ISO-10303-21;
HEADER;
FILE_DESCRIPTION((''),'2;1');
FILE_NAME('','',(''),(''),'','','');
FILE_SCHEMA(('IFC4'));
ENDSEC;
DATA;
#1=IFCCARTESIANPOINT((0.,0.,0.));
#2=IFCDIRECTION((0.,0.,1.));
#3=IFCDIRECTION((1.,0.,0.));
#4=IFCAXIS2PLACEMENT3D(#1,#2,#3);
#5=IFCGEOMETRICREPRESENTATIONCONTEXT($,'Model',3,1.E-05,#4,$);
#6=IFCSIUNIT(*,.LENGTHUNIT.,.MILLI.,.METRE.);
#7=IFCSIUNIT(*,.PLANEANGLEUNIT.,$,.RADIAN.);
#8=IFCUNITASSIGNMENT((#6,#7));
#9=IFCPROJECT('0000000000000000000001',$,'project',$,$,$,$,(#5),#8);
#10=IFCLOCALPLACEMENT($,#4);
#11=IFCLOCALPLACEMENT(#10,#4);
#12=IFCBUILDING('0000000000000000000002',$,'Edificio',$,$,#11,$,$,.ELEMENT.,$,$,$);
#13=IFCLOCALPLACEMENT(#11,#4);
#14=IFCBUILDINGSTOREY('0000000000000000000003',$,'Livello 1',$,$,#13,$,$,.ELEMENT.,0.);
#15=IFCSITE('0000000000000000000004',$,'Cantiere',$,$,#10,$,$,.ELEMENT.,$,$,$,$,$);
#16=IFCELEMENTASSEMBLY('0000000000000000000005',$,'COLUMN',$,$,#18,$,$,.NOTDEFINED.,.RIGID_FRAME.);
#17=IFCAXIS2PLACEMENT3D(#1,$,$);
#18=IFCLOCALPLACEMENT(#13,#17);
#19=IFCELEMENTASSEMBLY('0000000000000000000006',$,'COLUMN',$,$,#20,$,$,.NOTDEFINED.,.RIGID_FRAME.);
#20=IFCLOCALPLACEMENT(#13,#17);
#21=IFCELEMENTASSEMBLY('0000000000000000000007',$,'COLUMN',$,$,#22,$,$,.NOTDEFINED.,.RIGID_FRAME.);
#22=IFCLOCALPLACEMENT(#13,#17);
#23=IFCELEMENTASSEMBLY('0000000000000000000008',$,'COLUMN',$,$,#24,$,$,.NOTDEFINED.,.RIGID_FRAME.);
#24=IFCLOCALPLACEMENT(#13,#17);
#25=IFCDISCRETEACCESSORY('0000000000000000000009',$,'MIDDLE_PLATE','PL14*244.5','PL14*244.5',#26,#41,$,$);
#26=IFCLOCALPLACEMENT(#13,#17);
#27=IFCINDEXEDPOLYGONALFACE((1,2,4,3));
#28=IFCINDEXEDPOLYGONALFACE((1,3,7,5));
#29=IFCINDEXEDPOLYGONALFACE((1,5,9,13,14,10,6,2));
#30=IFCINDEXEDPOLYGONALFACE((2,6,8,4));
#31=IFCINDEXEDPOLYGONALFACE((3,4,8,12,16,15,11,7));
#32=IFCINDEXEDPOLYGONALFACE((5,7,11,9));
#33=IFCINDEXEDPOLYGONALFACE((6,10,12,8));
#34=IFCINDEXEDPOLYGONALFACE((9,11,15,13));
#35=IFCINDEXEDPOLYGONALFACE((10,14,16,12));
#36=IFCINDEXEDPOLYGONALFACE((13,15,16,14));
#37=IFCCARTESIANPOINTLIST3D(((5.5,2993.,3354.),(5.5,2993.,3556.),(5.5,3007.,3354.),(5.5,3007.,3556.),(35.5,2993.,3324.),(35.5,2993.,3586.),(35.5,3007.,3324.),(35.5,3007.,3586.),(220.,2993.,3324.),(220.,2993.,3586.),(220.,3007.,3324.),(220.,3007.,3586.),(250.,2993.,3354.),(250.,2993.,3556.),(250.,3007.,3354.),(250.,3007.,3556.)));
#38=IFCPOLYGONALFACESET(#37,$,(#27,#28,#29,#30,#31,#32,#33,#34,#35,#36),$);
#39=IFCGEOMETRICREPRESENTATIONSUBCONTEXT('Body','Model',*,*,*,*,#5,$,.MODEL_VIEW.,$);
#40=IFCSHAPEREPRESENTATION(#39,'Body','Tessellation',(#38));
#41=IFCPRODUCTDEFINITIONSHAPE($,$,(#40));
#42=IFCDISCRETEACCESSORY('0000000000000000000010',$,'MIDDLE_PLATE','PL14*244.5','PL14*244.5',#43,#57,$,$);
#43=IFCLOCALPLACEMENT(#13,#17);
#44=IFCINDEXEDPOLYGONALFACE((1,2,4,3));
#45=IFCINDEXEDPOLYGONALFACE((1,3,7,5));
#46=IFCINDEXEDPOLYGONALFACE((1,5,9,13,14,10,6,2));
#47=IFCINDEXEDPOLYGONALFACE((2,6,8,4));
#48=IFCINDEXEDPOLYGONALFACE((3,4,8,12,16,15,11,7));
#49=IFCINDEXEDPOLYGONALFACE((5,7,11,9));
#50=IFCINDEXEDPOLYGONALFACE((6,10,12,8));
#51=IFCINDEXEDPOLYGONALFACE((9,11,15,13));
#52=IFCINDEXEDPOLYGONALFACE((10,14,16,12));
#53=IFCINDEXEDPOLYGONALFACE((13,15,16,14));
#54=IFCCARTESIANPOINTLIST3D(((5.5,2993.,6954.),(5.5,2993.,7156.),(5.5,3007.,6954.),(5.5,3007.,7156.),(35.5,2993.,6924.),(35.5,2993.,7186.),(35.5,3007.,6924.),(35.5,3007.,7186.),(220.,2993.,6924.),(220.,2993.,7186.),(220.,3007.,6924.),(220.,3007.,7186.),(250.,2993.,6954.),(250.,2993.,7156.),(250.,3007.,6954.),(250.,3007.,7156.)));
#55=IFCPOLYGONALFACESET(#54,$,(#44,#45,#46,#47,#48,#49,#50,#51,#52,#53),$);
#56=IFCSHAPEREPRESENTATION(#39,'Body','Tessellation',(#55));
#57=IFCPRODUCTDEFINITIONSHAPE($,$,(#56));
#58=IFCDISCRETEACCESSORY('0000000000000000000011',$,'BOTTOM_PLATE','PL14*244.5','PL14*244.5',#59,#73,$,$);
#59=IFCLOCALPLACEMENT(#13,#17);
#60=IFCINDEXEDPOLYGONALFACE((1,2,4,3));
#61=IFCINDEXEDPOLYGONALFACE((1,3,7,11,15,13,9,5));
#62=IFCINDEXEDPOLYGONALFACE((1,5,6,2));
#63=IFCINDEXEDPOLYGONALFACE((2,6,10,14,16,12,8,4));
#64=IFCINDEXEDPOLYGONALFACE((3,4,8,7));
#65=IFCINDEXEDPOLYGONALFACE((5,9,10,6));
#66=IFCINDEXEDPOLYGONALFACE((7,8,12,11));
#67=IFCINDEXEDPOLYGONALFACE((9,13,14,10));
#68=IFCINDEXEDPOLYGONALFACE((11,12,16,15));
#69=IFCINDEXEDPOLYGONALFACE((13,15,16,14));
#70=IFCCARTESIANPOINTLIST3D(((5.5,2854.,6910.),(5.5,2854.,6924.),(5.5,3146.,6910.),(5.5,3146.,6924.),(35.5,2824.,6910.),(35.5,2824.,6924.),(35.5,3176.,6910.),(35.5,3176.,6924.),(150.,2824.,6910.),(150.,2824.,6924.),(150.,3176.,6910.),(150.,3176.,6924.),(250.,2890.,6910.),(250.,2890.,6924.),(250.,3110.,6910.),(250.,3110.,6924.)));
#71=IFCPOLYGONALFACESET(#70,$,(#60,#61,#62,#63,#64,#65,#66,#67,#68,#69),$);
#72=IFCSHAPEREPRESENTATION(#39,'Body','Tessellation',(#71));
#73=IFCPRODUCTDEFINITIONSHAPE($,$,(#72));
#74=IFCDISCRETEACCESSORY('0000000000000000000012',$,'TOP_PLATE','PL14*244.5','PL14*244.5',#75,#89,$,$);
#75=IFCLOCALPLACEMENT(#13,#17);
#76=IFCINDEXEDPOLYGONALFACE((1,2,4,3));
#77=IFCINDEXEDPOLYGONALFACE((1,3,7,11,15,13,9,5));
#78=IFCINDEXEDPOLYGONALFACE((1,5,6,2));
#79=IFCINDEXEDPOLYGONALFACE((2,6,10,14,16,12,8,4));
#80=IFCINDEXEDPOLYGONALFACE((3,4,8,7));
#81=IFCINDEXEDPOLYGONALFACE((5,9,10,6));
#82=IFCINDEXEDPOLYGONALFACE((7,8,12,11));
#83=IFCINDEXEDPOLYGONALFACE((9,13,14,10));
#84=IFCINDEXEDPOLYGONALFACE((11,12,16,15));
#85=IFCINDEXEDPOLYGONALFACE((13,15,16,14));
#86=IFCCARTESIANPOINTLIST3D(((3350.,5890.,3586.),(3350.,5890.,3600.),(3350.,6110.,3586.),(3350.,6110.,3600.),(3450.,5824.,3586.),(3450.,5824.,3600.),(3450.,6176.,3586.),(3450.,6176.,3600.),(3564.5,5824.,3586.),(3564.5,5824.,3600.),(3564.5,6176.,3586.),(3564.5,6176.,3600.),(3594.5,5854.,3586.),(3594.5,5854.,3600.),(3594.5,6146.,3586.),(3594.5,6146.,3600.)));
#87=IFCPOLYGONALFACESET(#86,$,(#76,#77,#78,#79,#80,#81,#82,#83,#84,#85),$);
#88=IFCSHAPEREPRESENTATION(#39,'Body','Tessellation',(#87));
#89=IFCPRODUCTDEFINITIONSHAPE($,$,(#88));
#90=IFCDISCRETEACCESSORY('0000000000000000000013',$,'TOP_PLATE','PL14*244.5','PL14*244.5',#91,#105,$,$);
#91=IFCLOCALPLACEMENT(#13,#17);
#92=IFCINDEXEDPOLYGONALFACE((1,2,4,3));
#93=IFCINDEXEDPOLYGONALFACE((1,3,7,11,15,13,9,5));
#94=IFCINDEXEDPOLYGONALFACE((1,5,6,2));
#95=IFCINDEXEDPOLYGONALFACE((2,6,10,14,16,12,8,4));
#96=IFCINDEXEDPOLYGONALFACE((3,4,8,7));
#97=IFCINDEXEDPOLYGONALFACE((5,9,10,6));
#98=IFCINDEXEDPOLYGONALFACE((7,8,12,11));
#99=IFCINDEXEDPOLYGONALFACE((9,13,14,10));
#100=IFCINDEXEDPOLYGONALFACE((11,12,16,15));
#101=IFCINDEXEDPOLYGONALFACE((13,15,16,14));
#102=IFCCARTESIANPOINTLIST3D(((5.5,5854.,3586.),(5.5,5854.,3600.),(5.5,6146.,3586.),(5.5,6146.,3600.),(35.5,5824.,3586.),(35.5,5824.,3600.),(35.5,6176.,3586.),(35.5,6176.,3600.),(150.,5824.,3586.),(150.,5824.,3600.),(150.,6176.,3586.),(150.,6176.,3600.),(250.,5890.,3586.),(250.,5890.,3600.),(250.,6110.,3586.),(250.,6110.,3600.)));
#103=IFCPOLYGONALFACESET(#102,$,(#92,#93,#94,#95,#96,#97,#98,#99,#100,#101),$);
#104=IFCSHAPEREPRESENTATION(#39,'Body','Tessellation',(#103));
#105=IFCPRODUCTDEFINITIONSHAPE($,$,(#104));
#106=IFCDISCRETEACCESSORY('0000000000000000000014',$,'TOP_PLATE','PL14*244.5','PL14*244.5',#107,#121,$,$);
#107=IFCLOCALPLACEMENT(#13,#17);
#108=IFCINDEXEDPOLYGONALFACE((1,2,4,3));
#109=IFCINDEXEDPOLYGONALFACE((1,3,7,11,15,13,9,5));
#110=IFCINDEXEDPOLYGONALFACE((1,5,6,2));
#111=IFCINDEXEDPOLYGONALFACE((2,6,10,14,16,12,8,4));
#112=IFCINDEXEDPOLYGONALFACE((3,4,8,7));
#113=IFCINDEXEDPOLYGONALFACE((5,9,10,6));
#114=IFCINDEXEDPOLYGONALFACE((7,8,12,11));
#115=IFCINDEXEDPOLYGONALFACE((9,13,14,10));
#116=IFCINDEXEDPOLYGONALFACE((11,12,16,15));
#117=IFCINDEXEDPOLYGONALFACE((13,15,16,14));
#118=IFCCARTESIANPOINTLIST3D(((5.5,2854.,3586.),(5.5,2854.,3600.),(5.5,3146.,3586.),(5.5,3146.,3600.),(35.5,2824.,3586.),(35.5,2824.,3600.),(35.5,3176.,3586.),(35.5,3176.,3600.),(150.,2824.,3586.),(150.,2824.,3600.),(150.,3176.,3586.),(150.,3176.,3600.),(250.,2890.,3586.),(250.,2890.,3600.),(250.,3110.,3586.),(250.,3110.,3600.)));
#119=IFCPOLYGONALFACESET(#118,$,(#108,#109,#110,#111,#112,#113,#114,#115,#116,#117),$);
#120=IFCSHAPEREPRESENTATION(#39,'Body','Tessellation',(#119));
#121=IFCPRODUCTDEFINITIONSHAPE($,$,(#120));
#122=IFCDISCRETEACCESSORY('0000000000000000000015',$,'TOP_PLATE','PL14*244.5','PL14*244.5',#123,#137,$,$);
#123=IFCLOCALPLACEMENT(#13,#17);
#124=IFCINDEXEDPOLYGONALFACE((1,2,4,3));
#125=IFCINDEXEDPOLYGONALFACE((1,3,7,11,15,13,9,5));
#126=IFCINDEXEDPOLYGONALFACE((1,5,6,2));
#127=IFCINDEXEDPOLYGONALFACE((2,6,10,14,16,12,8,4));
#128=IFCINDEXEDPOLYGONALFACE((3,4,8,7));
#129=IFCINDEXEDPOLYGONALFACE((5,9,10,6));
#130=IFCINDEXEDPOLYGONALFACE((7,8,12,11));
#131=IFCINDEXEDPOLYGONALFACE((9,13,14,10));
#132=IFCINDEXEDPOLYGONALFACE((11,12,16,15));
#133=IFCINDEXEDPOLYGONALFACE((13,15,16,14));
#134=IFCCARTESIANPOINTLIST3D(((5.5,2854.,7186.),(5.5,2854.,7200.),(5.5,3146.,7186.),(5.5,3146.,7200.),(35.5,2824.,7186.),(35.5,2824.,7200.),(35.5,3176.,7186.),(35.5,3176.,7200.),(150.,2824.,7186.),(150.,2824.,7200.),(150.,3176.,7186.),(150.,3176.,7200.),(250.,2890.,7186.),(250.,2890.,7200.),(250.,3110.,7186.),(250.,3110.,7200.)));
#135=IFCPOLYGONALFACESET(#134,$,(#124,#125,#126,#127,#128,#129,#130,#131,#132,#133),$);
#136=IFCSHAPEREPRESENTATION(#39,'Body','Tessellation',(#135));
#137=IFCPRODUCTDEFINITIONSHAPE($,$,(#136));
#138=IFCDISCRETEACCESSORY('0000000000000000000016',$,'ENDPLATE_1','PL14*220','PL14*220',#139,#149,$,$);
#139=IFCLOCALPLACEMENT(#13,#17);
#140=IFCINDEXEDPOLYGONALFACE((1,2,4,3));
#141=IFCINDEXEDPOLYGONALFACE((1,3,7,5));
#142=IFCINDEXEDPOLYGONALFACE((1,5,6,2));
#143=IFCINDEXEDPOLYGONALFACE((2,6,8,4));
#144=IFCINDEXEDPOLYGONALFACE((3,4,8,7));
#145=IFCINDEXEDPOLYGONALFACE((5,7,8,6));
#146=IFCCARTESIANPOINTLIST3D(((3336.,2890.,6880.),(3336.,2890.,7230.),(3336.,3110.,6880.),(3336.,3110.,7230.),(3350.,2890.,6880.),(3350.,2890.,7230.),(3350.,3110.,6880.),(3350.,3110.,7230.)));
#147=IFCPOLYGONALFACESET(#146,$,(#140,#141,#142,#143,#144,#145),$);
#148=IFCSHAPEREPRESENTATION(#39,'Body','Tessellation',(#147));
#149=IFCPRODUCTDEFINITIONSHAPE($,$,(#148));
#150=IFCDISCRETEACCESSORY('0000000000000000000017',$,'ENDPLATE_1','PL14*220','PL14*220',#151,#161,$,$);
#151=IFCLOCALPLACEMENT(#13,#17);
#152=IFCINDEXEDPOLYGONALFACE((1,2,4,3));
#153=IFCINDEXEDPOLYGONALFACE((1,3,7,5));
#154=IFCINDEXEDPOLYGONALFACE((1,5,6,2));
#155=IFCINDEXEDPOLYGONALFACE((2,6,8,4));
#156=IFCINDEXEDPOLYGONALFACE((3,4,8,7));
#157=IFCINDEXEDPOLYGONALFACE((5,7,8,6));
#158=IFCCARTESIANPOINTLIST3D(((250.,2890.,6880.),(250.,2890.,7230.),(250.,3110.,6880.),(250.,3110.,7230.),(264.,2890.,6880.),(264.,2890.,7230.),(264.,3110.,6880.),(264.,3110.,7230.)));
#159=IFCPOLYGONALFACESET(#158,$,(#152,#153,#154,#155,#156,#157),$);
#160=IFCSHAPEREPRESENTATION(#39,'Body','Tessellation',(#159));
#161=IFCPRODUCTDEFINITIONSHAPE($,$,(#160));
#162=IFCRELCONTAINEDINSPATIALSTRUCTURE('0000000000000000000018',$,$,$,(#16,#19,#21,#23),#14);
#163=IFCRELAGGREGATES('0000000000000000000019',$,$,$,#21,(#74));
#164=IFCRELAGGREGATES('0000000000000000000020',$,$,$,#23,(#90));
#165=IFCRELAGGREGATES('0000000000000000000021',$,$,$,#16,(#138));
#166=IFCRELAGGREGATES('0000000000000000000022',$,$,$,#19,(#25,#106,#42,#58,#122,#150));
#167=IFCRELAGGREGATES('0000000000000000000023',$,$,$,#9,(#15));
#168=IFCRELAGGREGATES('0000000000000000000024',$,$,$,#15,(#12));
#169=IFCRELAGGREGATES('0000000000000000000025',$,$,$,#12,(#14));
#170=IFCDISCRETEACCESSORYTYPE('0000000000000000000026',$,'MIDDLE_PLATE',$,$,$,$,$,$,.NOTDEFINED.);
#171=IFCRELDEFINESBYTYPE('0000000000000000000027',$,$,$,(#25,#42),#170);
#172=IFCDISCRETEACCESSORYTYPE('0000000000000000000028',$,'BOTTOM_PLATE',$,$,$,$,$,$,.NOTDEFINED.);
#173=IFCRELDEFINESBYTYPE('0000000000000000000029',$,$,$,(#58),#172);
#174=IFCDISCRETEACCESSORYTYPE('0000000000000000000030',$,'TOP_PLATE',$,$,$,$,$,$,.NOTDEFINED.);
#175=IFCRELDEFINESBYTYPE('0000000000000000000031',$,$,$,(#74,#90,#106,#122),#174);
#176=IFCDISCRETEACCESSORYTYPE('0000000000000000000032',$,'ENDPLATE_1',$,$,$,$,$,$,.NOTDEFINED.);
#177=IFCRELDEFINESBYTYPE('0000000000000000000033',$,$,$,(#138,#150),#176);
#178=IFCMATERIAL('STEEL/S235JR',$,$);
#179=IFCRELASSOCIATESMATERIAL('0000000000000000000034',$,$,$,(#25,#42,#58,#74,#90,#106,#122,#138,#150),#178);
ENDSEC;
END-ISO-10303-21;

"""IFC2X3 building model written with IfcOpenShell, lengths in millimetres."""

from ifc_helpers import new_model, si_unit, frame, origin_with_axes, place, context, subcontext, project, spatial, polyline, outline, extrude, material, type_object, element, aggregate, save


model = new_model("IFC2X3")

# Units and contexts
model_context = context("Model", 3, precision=1e-05, world=origin_with_axes())
body_context = subcontext(model_context, "Body", "Model", "MODEL_VIEW")
ifc_project = project(units=[si_unit("LENGTHUNIT", "METRE", prefix="MILLI"), si_unit("PLANEANGLEUNIT", "RADIAN")], contexts=[model_context])

# Site, building, storey
site_placement = place(None, origin_with_axes())
site = spatial("IfcSite", under=ifc_project, at=site_placement, Name="Cantiere", CompositionType="ELEMENT")
building_placement = place(site_placement, origin_with_axes())
building = spatial("IfcBuilding", under=site, at=building_placement, Name="Edificio", CompositionType="ELEMENT")
storey_placement = place(building_placement, origin_with_axes())
storey = spatial("IfcBuildingStorey", under=building, at=storey_placement, Name="Livello 1", CompositionType="ELEMENT", Elevation=0.0)

# Shared definitions
ifc_material_1 = material(Name="STEEL/S235JR")

# Element assemblies
assembly_1_placement = place(storey_placement, origin_with_axes())
assembly_1 = element("IfcElementAssembly", 1, at=assembly_1_placement, inside=storey, Name="COLUMN", AssemblyPlace="NOTDEFINED", PredefinedType="RIGID_FRAME")
assembly_2_placement = place(storey_placement, origin_with_axes())
assembly_2 = element("IfcElementAssembly", 2, at=assembly_2_placement, inside=storey, Name="COLUMN", AssemblyPlace="NOTDEFINED", PredefinedType="RIGID_FRAME")

# Element assemblies
assembly_3_placement = place(storey_placement, origin_with_axes())
assembly_3 = element("IfcElementAssembly", 3, at=assembly_3_placement, inside=storey, Name="COLUMN", AssemblyPlace="NOTDEFINED", PredefinedType="RIGID_FRAME")
discrete_accessory_type_1 = type_object("IfcDiscreteAccessoryType", Name="MIDDLE_PLATE")
assembly_4_placement = place(storey_placement, origin_with_axes())
assembly_4 = element("IfcElementAssembly", 4, at=assembly_4_placement, inside=storey, Name="COLUMN", AssemblyPlace="NOTDEFINED", PredefinedType="RIGID_FRAME")

# Discrete accessories
discrete_accessory_1_placement = place(assembly_2_placement, frame((250.0, 3000.0, 3586.0), z_axis=(0.0, -1.0, 0.0), x_axis=(-1.0, 0.0, 0.0)))
discrete_accessory_1 = element("IfcDiscreteAccessory", 5, at=discrete_accessory_1_placement, type_object=discrete_accessory_type_1, material=ifc_material_1, Name="MIDDLE_PLATE", Description="PL14*244.5", ObjectType="PL14*244.5", context=body_context, shape_type="SweptSolid", body=[
    extrude(outline(polyline([(0.0, 30.0), (30.0, 0.0), (214.5, 0.0), (244.5, 30.0), (244.5, 232.0), (214.5, 262.0), (30.0, 262.0), (0.0, 232.0), (0.0, 30.0)])), frame((0.0, 0.0, -7.0), z_axis=(0.0, 0.0, 1.0), x_axis=(1.0, 0.0, 0.0)), (0.0, 0.0, 1.0), 14.0),
])
discrete_accessory_2_placement = place(assembly_2_placement, frame((250.0, 3000.0, 7186.0), z_axis=(0.0, -1.0, 0.0), x_axis=(-1.0, 0.0, 0.0)))
discrete_accessory_2 = element("IfcDiscreteAccessory", 6, at=discrete_accessory_2_placement, type_object=discrete_accessory_type_1, material=ifc_material_1, Name="MIDDLE_PLATE", Description="PL14*244.5", ObjectType="PL14*244.5", context=body_context, shape_type="SweptSolid", body=[
    extrude(outline(polyline([(0.0, 30.0), (30.0, 0.0), (214.5, 0.0), (244.5, 30.0), (244.5, 232.0), (214.5, 262.0), (30.0, 262.0), (0.0, 232.0), (0.0, 30.0)])), frame((0.0, 0.0, -7.0), z_axis=(0.0, 0.0, 1.0), x_axis=(1.0, 0.0, 0.0)), (0.0, 0.0, 1.0), 14.0),
])
discrete_accessory_type_2 = type_object("IfcDiscreteAccessoryType", Name="BOTTOM_PLATE")
discrete_accessory_3_placement = place(assembly_2_placement, frame((5.5, 3176.0, 6917.0), z_axis=(0.0, 0.0, 1.0), x_axis=(0.0, -1.0, 0.0)))
discrete_accessory_3 = element("IfcDiscreteAccessory", 7, at=discrete_accessory_3_placement, type_object=discrete_accessory_type_2, material=ifc_material_1, Name="BOTTOM_PLATE", Description="PL14*244.5", ObjectType="PL14*244.5", context=body_context, shape_type="SweptSolid", body=[
    extrude(outline(polyline([(0.0, 30.0), (30.0, 0.0), (322.0, 0.0), (352.0, 30.0), (352.0, 144.5), (286.0, 244.5), (66.0, 244.5), (0.0, 144.5), (0.0, 30.0)])), frame((0.0, 0.0, -7.0), z_axis=(0.0, 0.0, 1.0), x_axis=(1.0, 0.0, 0.0)), (0.0, 0.0, 1.0), 14.0),
])
discrete_accessory_type_3 = type_object("IfcDiscreteAccessoryType", Name="TOP_PLATE")
discrete_accessory_4_placement = place(assembly_3_placement, frame((3450.0, 5824.0, 3593.0), z_axis=(0.0, 0.0, 1.0), x_axis=(1.0, 0.0, 0.0)))
discrete_accessory_4 = element("IfcDiscreteAccessory", 8, at=discrete_accessory_4_placement, type_object=discrete_accessory_type_3, material=ifc_material_1, Name="TOP_PLATE", Description="PL14*244.5", ObjectType="PL14*244.5", context=body_context, shape_type="SweptSolid", body=[
    extrude(outline(polyline([(0.0, 0.0), (114.5, 0.0), (144.5, 30.0), (144.5, 322.0), (114.5, 352.0), (0.0, 352.0), (-100.0, 286.0), (-100.0, 66.0), (0.0, 0.0)])), frame((0.0, 0.0, -7.0), z_axis=(0.0, 0.0, 1.0), x_axis=(1.0, 0.0, 0.0)), (0.0, 0.0, 1.0), 14.0),
])
aggregate(assembly_3, [discrete_accessory_4])
discrete_accessory_5_placement = place(assembly_4_placement, frame((150.0, 6176.0, 3593.0), z_axis=(0.0, 0.0, 1.0), x_axis=(-1.0, 0.0, 0.0)))
discrete_accessory_5 = element("IfcDiscreteAccessory", 9, at=discrete_accessory_5_placement, type_object=discrete_accessory_type_3, material=ifc_material_1, Name="TOP_PLATE", Description="PL14*244.5", ObjectType="PL14*244.5", context=body_context, shape_type="SweptSolid", body=[
    extrude(outline(polyline([(0.0, 0.0), (114.5, 0.0), (144.5, 30.0), (144.5, 322.0), (114.5, 352.0), (0.0, 352.0), (-100.0, 286.0), (-100.0, 66.0), (0.0, 0.0)])), frame((0.0, 0.0, -7.0), z_axis=(0.0, 0.0, 1.0), x_axis=(1.0, 0.0, 0.0)), (0.0, 0.0, 1.0), 14.0),
])
aggregate(assembly_4, [discrete_accessory_5])
discrete_accessory_6_placement = place(assembly_2_placement, frame((150.0, 3176.0, 3593.0), z_axis=(0.0, 0.0, 1.0), x_axis=(-1.0, 0.0, 0.0)))
discrete_accessory_6 = element("IfcDiscreteAccessory", 10, at=discrete_accessory_6_placement, type_object=discrete_accessory_type_3, material=ifc_material_1, Name="TOP_PLATE", Description="PL14*244.5", ObjectType="PL14*244.5", context=body_context, shape_type="SweptSolid", body=[
    extrude(outline(polyline([(0.0, 0.0), (114.5, 0.0), (144.5, 30.0), (144.5, 322.0), (114.5, 352.0), (0.0, 352.0), (-100.0, 286.0), (-100.0, 66.0), (0.0, 0.0)])), frame((0.0, 0.0, -7.0), z_axis=(0.0, 0.0, 1.0), x_axis=(1.0, 0.0, 0.0)), (0.0, 0.0, 1.0), 14.0),
])
discrete_accessory_7_placement = place(assembly_2_placement, frame((150.0, 3176.0, 7193.0), z_axis=(0.0, 0.0, 1.0), x_axis=(-1.0, 0.0, 0.0)))
discrete_accessory_7 = element("IfcDiscreteAccessory", 11, at=discrete_accessory_7_placement, type_object=discrete_accessory_type_3, material=ifc_material_1, Name="TOP_PLATE", Description="PL14*244.5", ObjectType="PL14*244.5", context=body_context, shape_type="SweptSolid", body=[
    extrude(outline(polyline([(0.0, 0.0), (114.5, 0.0), (144.5, 30.0), (144.5, 322.0), (114.5, 352.0), (0.0, 352.0), (-100.0, 286.0), (-100.0, 66.0), (0.0, 0.0)])), frame((0.0, 0.0, -7.0), z_axis=(0.0, 0.0, 1.0), x_axis=(1.0, 0.0, 0.0)), (0.0, 0.0, 1.0), 14.0),
])
discrete_accessory_type_4 = type_object("IfcDiscreteAccessoryType", Name="ENDPLATE_1")
discrete_accessory_8_placement = place(assembly_1_placement, frame((3343.0, 2890.0, 6880.0), z_axis=(-1.0, 0.0, 0.0), x_axis=(0.0, 0.0, 1.0)))
discrete_accessory_8 = element("IfcDiscreteAccessory", 12, at=discrete_accessory_8_placement, type_object=discrete_accessory_type_4, material=ifc_material_1, Name="ENDPLATE_1", Description="PL14*220", ObjectType="PL14*220", context=body_context, shape_type="SweptSolid", body=[
    extrude(outline(polyline([(0.0, 0.0), (350.0, 0.0), (350.0, 220.0), (0.0, 220.0), (0.0, 0.0)])), frame((0.0, 0.0, -7.0), z_axis=(0.0, 0.0, 1.0), x_axis=(1.0, 0.0, 0.0)), (0.0, 0.0, 1.0), 14.0),
])
aggregate(assembly_1, [discrete_accessory_8])
discrete_accessory_9_placement = place(assembly_2_placement, frame((257.0, 3110.0, 6880.0), z_axis=(1.0, 0.0, 0.0), x_axis=(0.0, 0.0, 1.0)))
discrete_accessory_9 = element("IfcDiscreteAccessory", 13, at=discrete_accessory_9_placement, type_object=discrete_accessory_type_4, material=ifc_material_1, Name="ENDPLATE_1", Description="PL14*220", ObjectType="PL14*220", context=body_context, shape_type="SweptSolid", body=[
    extrude(outline(polyline([(0.0, 0.0), (350.0, 0.0), (350.0, 220.0), (0.0, 220.0), (0.0, 0.0)])), frame((0.0, 0.0, -7.0), z_axis=(0.0, 0.0, 1.0), x_axis=(1.0, 0.0, 0.0)), (0.0, 0.0, 1.0), 14.0),
])
aggregate(assembly_2, [discrete_accessory_1, discrete_accessory_6, discrete_accessory_2, discrete_accessory_3, discrete_accessory_7, discrete_accessory_9])

save(model, "model.ifc")
